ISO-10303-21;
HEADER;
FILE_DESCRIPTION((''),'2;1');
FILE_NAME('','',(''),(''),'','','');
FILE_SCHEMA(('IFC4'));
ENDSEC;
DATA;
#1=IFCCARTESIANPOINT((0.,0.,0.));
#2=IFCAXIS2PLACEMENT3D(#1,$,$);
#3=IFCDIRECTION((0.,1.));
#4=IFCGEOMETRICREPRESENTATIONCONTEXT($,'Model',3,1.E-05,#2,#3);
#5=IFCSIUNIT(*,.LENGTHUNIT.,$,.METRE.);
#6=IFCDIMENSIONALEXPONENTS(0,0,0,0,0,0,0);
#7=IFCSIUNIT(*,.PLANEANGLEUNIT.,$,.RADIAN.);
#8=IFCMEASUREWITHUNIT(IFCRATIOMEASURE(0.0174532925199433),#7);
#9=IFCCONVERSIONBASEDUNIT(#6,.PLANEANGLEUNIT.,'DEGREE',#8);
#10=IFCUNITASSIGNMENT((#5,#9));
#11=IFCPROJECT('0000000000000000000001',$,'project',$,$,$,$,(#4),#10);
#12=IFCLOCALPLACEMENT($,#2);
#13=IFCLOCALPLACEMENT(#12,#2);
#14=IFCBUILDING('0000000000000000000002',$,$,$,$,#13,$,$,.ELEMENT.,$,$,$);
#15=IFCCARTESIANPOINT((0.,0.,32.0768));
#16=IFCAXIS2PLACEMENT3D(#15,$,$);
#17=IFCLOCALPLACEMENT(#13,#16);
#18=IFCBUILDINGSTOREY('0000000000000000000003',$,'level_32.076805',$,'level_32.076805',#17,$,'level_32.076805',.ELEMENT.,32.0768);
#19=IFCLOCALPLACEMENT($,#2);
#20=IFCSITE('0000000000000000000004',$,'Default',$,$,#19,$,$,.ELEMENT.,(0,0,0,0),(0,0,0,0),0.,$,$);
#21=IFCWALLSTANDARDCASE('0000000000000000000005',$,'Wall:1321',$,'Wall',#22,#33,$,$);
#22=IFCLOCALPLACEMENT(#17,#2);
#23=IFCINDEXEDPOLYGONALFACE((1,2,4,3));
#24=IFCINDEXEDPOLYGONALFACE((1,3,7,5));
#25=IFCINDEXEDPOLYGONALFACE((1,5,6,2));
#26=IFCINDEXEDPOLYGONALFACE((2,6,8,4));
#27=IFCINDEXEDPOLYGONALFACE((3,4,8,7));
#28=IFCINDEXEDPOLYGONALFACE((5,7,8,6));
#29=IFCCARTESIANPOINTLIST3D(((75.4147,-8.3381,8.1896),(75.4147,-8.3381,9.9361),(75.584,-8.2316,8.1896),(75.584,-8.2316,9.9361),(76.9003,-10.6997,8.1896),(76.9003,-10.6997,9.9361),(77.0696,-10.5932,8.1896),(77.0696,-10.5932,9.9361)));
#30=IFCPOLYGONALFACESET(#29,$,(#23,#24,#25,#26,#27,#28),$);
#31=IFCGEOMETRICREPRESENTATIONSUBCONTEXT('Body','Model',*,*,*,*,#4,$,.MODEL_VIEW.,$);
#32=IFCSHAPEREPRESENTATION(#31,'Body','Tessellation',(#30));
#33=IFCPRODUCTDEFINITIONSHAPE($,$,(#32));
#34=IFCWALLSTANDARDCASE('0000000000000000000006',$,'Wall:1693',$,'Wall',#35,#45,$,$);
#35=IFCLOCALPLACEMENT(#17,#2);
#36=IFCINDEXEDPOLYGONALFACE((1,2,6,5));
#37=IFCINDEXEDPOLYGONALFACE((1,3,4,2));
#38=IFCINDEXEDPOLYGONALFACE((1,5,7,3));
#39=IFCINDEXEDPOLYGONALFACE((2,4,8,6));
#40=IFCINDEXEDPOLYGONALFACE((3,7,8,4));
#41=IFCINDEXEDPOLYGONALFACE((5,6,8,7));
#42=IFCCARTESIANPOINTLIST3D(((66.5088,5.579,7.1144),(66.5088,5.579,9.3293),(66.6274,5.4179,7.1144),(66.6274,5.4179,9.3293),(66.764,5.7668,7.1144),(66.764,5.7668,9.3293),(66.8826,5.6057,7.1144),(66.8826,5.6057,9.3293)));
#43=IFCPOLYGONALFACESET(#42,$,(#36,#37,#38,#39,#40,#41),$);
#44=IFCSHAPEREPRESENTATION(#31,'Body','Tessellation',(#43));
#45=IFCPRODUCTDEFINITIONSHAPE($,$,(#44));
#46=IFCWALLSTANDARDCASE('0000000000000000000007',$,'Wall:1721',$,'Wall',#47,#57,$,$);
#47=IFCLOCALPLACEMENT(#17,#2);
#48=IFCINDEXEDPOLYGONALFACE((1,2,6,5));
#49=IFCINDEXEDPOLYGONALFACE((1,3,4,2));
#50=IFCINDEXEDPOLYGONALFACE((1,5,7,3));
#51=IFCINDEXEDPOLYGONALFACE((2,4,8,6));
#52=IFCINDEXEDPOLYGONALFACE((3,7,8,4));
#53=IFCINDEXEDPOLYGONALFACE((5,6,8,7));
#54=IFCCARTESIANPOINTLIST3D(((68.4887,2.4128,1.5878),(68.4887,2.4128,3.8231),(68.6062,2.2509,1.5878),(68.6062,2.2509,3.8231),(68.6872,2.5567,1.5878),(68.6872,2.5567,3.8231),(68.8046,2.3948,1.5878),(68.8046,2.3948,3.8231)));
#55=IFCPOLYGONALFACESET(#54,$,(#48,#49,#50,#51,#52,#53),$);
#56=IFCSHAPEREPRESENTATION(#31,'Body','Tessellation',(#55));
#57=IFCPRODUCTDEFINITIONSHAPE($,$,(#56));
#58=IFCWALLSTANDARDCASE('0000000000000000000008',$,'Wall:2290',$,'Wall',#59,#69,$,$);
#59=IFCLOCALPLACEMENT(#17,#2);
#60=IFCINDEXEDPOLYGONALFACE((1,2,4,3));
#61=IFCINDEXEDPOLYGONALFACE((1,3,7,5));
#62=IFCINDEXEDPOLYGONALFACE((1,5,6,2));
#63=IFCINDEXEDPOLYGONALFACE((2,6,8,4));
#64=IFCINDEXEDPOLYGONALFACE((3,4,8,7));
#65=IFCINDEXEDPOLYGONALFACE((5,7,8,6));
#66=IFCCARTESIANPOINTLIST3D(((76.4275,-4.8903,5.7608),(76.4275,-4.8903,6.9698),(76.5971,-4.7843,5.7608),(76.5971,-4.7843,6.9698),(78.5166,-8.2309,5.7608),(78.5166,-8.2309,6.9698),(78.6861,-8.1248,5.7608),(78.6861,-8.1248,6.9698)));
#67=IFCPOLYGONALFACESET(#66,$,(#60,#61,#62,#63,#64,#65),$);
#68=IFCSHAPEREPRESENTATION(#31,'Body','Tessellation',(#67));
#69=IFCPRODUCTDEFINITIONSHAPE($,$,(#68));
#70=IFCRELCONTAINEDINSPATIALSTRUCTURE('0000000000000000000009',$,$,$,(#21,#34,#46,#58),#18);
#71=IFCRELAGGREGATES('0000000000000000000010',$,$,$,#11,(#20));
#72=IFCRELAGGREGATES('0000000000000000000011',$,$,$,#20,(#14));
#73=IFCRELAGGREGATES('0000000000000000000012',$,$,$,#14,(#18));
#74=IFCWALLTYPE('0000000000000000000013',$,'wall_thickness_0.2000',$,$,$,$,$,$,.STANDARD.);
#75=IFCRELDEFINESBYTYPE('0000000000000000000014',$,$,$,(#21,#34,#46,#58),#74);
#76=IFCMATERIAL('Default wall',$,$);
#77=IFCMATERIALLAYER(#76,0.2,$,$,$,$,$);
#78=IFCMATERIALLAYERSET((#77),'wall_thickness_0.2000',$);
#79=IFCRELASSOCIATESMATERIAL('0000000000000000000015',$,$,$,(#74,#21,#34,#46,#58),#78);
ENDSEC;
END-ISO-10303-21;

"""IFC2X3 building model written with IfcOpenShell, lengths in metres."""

from ifc_helpers import new_model, entity, si_unit, converted_unit, direction, frame, origin, place, context, subcontext, project, spatial, polyline, outline, extrude, material, layer, layer_set, layer_usage, type_object, element, save


model = new_model("IFC2X3")

# Units and contexts
model_context = context("Model", 3, precision=1e-05, world=origin(), true_north=direction((0.0, 1.0)))
body_context = subcontext(model_context, "Body", "Model", "MODEL_VIEW")
ifc_project = project(units=[si_unit("LENGTHUNIT", "METRE"), converted_unit("PLANEANGLEUNIT", "DEGREE", entity("IfcRatioMeasure", 0.0174532925199433), si_unit("PLANEANGLEUNIT", "RADIAN"), dimensions=[0, 0, 0, 0, 0, 0, 0])], contexts=[model_context])

# Site, building, storey
site_placement = place(None, origin())
site = spatial("IfcSite", under=ifc_project, at=site_placement, Name="Default", CompositionType="ELEMENT", RefLatitude=(0, 0, 0, 0), RefLongitude=(0, 0, 0, 0), RefElevation=0.0)
placement_1 = place(None, origin())
building_placement = place(placement_1, origin())
building = spatial("IfcBuilding", under=site, at=building_placement, CompositionType="ELEMENT")
storey_placement = place(building_placement, frame((0.0, 0.0, 32.0768)))
storey = spatial("IfcBuildingStorey", under=building, at=storey_placement, Name="level_32.076805", ObjectType="level_32.076805", LongName="level_32.076805", CompositionType="ELEMENT", Elevation=32.0768)

# Shared definitions
ifc_material_1 = material(Name="Default wall")
ifc_layer = layer(ifc_material_1, 0.2)
ifc_layer_set = layer_set([ifc_layer], Name="wall_thickness_0.2000")
ifc_layer_usage = layer_usage(ifc_layer_set, "AXIS2", "POSITIVE", -0.1)
wall_type = type_object("IfcWallType", Name="wall_thickness_0.2000", PredefinedType="STANDARD", material=ifc_layer_set)

# Walls
placement_2 = place(building_placement, frame((0.0, 0.0, 40.2664)))
wall_1_placement = place(placement_2, frame((75.4993, -8.2848, 0.0), z_axis=(0.0, 0.0, 1.0), x_axis=(0.53248, -0.846443, 0.0)))
element("IfcWallStandardCase", 1, at=wall_1_placement, inside=storey, type_object=wall_type, material=ifc_layer_usage, Name="Wall:1321", ObjectType="Wall", context=body_context, shape_type="SweptSolid", body=[
    extrude(outline(polyline([(2.79, -0.1), (2.79, 0.1), (0.0, 0.1), (0.0, -0.1), (2.79, -0.1)])), origin(), (0.0, 0.0, 1.0), 1.7465),
])
placement_3 = place(building_placement, frame((0.0, 0.0, 39.1912)))
wall_2_placement = place(placement_3, frame((66.8233, 5.6863, 0.0), z_axis=(0.0, 0.0, 1.0), x_axis=(-0.805335, -0.592821, 0.0)))
element("IfcWallStandardCase", 2, at=wall_2_placement, inside=storey, type_object=wall_type, material=ifc_layer_usage, Name="Wall:1693", ObjectType="Wall", context=body_context, shape_type="SweptSolid", body=[
    extrude(outline(polyline([(0.3168, -0.1), (0.3168, 0.1), (0.0, 0.1), (0.0, -0.1), (0.3168, -0.1)])), origin(), (0.0, 0.0, 1.0), 2.2149),
])
placement_4 = place(building_placement, frame((0.0, 0.0, 33.6646)))
wall_3_placement = place(placement_4, frame((68.7459, 2.4758, 0.0), z_axis=(0.0, 0.0, 1.0), x_axis=(-0.809496, -0.587125, 0.0)))
element("IfcWallStandardCase", 3, at=wall_3_placement, inside=storey, type_object=wall_type, material=ifc_layer_usage, Name="Wall:1721", ObjectType="Wall", context=body_context, shape_type="SweptSolid", body=[
    extrude(outline(polyline([(0.2452, -0.1), (0.2452, 0.1), (0.0, 0.1), (0.0, -0.1), (0.2452, -0.1)])), origin(), (0.0, 0.0, 1.0), 2.2353),
])
placement_5 = place(building_placement, frame((0.0, 0.0, 37.8376)))
wall_4_placement = place(placement_5, frame((76.5123, -4.8373, 0.0), z_axis=(0.0, 0.0, 1.0), x_axis=(0.530212, -0.847865, 0.0)))
element("IfcWallStandardCase", 4, at=wall_4_placement, inside=storey, type_object=wall_type, material=ifc_layer_usage, Name="Wall:2290", ObjectType="Wall", context=body_context, shape_type="SweptSolid", body=[
    extrude(outline(polyline([(3.94, -0.1), (3.94, 0.1), (0.0, 0.1), (0.0, -0.1), (3.94, -0.1)])), origin(), (0.0, 0.0, 1.0), 1.209),
])

save(model, "model.ifc")
